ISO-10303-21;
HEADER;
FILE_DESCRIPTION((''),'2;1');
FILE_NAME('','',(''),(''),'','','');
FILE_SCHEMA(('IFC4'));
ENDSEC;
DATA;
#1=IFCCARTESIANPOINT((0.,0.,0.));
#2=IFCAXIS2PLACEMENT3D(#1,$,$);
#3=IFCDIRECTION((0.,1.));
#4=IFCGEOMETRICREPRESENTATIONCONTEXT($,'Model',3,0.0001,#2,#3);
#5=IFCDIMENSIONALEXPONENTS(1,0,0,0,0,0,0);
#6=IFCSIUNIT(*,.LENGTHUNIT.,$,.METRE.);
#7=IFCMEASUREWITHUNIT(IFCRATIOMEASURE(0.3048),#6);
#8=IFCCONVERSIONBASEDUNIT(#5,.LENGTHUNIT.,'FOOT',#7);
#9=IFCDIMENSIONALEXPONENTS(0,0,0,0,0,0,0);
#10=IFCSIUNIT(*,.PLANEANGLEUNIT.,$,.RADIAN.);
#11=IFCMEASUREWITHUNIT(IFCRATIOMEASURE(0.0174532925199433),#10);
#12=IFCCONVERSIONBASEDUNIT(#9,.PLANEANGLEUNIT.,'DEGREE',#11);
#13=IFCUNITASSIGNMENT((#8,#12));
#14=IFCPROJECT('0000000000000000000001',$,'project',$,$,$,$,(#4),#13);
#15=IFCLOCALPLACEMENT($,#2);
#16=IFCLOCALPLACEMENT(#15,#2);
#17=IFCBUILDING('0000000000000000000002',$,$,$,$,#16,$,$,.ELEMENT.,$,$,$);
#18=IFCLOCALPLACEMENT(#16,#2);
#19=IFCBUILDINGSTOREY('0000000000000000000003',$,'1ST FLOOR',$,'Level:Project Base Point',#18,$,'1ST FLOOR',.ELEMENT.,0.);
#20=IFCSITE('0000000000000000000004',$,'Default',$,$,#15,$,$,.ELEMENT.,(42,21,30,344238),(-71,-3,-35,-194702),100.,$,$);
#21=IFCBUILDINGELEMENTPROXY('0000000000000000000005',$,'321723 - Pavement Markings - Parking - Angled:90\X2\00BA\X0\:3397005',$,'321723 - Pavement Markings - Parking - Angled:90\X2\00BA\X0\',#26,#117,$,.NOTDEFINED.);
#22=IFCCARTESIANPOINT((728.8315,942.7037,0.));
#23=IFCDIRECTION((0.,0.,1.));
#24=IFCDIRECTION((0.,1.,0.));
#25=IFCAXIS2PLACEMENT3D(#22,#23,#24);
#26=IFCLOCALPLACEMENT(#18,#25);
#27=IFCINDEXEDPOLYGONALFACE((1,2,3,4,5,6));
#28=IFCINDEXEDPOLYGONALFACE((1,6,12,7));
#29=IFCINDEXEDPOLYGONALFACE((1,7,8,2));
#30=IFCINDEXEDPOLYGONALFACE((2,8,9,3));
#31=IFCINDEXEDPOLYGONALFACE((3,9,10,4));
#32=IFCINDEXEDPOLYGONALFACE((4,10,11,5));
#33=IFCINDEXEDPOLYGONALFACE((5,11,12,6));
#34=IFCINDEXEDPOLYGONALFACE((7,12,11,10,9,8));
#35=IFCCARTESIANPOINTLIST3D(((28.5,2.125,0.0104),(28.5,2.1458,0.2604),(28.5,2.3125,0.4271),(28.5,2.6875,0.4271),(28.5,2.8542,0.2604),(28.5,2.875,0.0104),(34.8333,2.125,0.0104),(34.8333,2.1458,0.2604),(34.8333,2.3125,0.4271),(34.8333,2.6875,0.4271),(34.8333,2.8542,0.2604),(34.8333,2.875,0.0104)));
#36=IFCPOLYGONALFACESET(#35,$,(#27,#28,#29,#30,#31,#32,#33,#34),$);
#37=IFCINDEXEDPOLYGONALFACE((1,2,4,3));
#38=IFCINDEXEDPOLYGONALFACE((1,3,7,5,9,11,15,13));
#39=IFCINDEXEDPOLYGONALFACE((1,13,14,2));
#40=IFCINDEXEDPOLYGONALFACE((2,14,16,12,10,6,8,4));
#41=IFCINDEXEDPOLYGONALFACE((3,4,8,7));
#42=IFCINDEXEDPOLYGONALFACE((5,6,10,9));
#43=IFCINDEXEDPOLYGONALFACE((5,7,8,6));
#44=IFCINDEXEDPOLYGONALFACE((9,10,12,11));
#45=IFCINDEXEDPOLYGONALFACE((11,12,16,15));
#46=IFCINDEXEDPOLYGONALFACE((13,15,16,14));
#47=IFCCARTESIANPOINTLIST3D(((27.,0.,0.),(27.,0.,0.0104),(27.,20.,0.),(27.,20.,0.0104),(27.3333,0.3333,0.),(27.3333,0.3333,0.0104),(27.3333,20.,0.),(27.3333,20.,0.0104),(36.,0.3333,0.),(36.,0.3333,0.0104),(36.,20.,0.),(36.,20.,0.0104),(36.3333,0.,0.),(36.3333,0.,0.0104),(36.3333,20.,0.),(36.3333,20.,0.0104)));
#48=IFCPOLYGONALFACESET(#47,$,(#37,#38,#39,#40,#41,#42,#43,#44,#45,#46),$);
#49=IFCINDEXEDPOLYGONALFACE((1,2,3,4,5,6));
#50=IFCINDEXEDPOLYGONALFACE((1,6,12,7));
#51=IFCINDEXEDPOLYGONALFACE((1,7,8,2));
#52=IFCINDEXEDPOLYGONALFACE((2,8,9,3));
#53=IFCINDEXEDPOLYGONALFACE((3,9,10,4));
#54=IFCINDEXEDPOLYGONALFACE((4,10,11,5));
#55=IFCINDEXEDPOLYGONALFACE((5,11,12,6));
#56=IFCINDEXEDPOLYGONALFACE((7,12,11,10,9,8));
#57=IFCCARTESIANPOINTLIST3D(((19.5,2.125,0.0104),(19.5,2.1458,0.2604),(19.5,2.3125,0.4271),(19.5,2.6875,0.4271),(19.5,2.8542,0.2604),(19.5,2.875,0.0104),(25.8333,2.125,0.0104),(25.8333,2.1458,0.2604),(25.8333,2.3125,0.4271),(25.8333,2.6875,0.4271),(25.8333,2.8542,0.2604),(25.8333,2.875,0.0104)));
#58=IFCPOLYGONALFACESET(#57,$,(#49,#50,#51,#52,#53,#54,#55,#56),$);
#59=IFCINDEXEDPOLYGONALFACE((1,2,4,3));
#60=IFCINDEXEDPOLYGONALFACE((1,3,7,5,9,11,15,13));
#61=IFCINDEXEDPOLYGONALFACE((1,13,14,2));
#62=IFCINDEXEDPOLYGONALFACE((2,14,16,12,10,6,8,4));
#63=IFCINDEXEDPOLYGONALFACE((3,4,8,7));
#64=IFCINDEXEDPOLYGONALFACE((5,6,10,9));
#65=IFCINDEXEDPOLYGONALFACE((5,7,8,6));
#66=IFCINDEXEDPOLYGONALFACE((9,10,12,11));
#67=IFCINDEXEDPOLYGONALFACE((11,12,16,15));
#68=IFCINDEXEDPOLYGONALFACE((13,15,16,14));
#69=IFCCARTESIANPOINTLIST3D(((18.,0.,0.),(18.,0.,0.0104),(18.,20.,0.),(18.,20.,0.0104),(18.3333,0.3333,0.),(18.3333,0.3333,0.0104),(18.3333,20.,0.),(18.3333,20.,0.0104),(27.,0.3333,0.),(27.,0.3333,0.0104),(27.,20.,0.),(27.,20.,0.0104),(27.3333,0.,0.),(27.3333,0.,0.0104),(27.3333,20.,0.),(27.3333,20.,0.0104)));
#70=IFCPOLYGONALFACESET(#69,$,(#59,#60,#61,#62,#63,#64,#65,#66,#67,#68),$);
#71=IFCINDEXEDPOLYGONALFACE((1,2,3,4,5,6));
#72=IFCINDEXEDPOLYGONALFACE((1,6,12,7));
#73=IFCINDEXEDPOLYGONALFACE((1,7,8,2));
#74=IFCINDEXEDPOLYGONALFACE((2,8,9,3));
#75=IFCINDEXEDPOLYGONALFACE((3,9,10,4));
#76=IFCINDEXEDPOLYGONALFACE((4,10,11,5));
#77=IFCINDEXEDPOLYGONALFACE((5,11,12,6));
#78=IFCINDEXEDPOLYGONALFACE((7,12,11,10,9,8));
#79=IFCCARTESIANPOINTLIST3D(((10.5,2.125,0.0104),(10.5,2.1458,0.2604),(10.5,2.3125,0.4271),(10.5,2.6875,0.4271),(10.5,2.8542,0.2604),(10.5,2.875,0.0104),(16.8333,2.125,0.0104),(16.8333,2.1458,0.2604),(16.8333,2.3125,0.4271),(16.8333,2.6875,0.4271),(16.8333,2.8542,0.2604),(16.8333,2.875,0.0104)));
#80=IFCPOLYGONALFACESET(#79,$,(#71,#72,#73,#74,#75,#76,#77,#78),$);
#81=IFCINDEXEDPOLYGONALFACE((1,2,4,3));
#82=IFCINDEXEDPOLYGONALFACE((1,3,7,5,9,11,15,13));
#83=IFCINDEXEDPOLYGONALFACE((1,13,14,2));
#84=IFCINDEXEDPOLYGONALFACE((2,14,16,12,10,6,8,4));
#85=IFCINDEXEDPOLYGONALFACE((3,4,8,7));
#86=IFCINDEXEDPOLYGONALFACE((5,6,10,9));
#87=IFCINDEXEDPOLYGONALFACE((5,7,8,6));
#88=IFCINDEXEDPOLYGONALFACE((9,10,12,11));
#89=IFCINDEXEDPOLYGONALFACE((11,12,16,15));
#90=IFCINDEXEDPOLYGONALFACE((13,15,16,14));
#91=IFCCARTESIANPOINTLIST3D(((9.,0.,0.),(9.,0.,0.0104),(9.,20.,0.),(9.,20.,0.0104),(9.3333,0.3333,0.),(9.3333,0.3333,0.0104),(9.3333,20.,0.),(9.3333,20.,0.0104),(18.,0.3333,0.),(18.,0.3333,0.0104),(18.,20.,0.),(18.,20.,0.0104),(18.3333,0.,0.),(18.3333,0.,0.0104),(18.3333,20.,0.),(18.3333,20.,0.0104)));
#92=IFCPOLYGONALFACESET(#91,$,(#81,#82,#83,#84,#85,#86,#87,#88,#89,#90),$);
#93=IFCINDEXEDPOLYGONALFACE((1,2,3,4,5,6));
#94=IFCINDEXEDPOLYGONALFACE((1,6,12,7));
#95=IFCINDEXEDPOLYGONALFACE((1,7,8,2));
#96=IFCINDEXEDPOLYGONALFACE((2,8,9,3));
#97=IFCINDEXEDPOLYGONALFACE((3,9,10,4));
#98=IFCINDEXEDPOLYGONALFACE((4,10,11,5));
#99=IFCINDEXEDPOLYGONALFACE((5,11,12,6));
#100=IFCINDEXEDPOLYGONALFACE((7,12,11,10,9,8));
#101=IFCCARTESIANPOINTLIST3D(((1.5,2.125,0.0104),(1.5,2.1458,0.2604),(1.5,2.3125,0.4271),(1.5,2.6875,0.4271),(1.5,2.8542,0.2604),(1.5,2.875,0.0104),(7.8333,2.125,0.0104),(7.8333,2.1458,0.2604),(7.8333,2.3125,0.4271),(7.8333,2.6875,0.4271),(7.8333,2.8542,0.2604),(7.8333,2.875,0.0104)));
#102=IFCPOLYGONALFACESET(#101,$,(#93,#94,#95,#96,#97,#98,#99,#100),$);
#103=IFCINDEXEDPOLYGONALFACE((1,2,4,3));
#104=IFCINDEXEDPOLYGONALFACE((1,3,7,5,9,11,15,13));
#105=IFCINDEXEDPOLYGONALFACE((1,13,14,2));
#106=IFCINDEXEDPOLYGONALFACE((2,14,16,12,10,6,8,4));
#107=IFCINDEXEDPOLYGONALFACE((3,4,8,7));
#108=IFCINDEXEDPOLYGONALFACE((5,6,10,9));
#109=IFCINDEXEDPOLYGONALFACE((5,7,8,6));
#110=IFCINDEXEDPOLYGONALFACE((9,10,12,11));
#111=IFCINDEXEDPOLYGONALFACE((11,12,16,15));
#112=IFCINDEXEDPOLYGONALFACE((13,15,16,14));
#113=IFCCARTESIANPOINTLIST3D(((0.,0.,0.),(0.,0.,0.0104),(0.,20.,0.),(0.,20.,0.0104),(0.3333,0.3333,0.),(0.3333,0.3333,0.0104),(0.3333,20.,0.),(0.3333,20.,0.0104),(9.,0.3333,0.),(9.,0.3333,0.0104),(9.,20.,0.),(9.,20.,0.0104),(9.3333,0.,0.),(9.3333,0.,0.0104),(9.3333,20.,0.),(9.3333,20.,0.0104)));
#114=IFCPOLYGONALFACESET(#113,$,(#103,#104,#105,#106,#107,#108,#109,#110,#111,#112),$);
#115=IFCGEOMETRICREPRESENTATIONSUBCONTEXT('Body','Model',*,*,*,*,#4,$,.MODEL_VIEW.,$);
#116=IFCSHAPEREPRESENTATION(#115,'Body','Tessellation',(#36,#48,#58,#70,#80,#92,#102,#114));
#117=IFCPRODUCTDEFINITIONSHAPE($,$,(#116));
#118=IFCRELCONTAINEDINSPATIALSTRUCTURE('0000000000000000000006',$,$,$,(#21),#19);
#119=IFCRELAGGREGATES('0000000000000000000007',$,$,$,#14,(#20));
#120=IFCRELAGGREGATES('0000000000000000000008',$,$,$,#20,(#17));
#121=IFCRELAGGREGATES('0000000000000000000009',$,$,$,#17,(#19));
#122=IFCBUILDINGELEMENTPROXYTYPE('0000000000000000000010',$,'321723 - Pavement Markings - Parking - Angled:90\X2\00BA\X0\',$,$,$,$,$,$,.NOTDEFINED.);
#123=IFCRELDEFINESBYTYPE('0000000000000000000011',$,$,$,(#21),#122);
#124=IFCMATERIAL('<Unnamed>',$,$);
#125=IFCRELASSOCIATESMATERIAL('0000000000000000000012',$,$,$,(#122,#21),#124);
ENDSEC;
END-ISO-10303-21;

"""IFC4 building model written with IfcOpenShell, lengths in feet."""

from ifc_helpers import new_model, entity, si_unit, converted_unit, direction, frame, origin, place, context, subcontext, project, spatial, polyline, outline, extrude, source, transform, mapped, material, type_object, type_shapes, element, save


model = new_model("IFC4")

# Units and contexts
model_context = context("Model", 3, precision=0.0001, world=origin(), true_north=direction((0.0, 1.0)))
body_context = subcontext(model_context, "Body", "Model", "MODEL_VIEW")
ifc_project = project(units=[converted_unit("LENGTHUNIT", "FOOT", entity("IfcRatioMeasure", 0.3048), si_unit("LENGTHUNIT", "METRE"), dimensions=[1, 0, 0, 0, 0, 0, 0]), converted_unit("PLANEANGLEUNIT", "DEGREE", entity("IfcRatioMeasure", 0.0174532925199433), si_unit("PLANEANGLEUNIT", "RADIAN"), dimensions=[0, 0, 0, 0, 0, 0, 0])], contexts=[model_context])

# Site, building, storey
site_placement = place(None, origin())
site = spatial("IfcSite", under=ifc_project, at=site_placement, Name="Default", CompositionType="ELEMENT", RefLatitude=(42, 21, 30, 344238), RefLongitude=(-71, -3, -35, -194702), RefElevation=100.0)
building_placement = place(site_placement, origin())
building = spatial("IfcBuilding", under=site, at=building_placement, CompositionType="ELEMENT")
storey_placement = place(building_placement, origin())
storey = spatial("IfcBuildingStorey", under=building, at=storey_placement, Name="1ST FLOOR", ObjectType="Level:Project Base Point", LongName="1ST FLOOR", CompositionType="ELEMENT", Elevation=0.0)

# Building element proxy
ifc_material_1 = material(Name="<Unnamed>")
building_element_proxy_type_1 = type_object("IfcBuildingElementProxyType", Name="321723 - Pavement Markings - Parking - Angled:90º", PredefinedType="NOTDEFINED", material=ifc_material_1)
shared_shape_1 = source(origin(), body_context, "Body", "SweptSolid", [
    extrude(outline(polyline([(-0.375, -0.2222), (0.375, -0.2222), (0.3542, 0.0278), (0.1875, 0.1944), (-0.1875, 0.1944), (-0.3542, 0.0278), (-0.375, -0.2222)])), frame((28.5, 2.5, 0.2326), z_axis=(1.0, 0.0, 0.0), x_axis=(0.0, 1.0, 0.0)), (0.0, 0.0, 1.0), 6.3333),
    extrude(outline(polyline([(-4.6667, -10.0833), (4.6667, -10.0833), (4.6667, 9.9167), (4.3333, 9.9167), (4.3333, -9.75), (-4.3333, -9.75), (-4.3333, 9.9167), (-4.6667, 9.9167), (-4.6667, -10.0833)])), frame((31.6667, 10.0833, 0.0)), (0.0, 0.0, 1.0), 0.0104),
    extrude(outline(polyline([(-0.375, -0.2222), (0.375, -0.2222), (0.3542, 0.0278), (0.1875, 0.1944), (-0.1875, 0.1944), (-0.3542, 0.0278), (-0.375, -0.2222)])), frame((19.5, 2.5, 0.2326), z_axis=(1.0, 0.0, 0.0), x_axis=(0.0, 1.0, 0.0)), (0.0, 0.0, 1.0), 6.3333),
    extrude(outline(polyline([(-4.6667, -10.0833), (4.6667, -10.0833), (4.6667, 9.9167), (4.3333, 9.9167), (4.3333, -9.75), (-4.3333, -9.75), (-4.3333, 9.9167), (-4.6667, 9.9167), (-4.6667, -10.0833)])), frame((22.6667, 10.0833, 0.0)), (0.0, 0.0, 1.0), 0.0104),
    extrude(outline(polyline([(-0.375, -0.2222), (0.375, -0.2222), (0.3542, 0.0278), (0.1875, 0.1944), (-0.1875, 0.1944), (-0.3542, 0.0278), (-0.375, -0.2222)])), frame((10.5, 2.5, 0.2326), z_axis=(1.0, 0.0, 0.0), x_axis=(0.0, 1.0, 0.0)), (0.0, 0.0, 1.0), 6.3333),
    extrude(outline(polyline([(-4.6667, -10.0833), (4.6667, -10.0833), (4.6667, 9.9167), (4.3333, 9.9167), (4.3333, -9.75), (-4.3333, -9.75), (-4.3333, 9.9167), (-4.6667, 9.9167), (-4.6667, -10.0833)])), frame((13.6667, 10.0833, 0.0)), (0.0, 0.0, 1.0), 0.0104),
    extrude(outline(polyline([(-0.375, -0.2222), (0.375, -0.2222), (0.3542, 0.0278), (0.1875, 0.1944), (-0.1875, 0.1944), (-0.3542, 0.0278), (-0.375, -0.2222)])), frame((1.5, 2.5, 0.2326), z_axis=(1.0, 0.0, 0.0), x_axis=(0.0, 1.0, 0.0)), (0.0, 0.0, 1.0), 6.3333),
    extrude(outline(polyline([(-4.6667, -10.0833), (4.6667, -10.0833), (4.6667, 9.9167), (4.3333, 9.9167), (4.3333, -9.75), (-4.3333, -9.75), (-4.3333, 9.9167), (-4.6667, 9.9167), (-4.6667, -10.0833)])), frame((4.6667, 10.0833, 0.0)), (0.0, 0.0, 1.0), 0.0104),
])
type_shapes(building_element_proxy_type_1, [shared_shape_1])
proxy_1_placement = place(storey_placement, frame((728.8315, 942.7037, 0.0), z_axis=(0.0, 0.0, 1.0), x_axis=(0.0, 1.0, 0.0)))
element("IfcBuildingElementProxy", 1, at=proxy_1_placement, inside=storey, type_object=building_element_proxy_type_1, material=ifc_material_1, Name="321723 - Pavement Markings - Parking - Angled:90º:3397005", ObjectType="321723 - Pavement Markings - Parking - Angled:90º", PredefinedType="NOTDEFINED", context=body_context, shape_type="MappedRepresentation", body=[
    mapped(shared_shape_1, transform((0.0, 0.0, 0.0), scale=1.0)),
])

save(model, "model.ifc")
